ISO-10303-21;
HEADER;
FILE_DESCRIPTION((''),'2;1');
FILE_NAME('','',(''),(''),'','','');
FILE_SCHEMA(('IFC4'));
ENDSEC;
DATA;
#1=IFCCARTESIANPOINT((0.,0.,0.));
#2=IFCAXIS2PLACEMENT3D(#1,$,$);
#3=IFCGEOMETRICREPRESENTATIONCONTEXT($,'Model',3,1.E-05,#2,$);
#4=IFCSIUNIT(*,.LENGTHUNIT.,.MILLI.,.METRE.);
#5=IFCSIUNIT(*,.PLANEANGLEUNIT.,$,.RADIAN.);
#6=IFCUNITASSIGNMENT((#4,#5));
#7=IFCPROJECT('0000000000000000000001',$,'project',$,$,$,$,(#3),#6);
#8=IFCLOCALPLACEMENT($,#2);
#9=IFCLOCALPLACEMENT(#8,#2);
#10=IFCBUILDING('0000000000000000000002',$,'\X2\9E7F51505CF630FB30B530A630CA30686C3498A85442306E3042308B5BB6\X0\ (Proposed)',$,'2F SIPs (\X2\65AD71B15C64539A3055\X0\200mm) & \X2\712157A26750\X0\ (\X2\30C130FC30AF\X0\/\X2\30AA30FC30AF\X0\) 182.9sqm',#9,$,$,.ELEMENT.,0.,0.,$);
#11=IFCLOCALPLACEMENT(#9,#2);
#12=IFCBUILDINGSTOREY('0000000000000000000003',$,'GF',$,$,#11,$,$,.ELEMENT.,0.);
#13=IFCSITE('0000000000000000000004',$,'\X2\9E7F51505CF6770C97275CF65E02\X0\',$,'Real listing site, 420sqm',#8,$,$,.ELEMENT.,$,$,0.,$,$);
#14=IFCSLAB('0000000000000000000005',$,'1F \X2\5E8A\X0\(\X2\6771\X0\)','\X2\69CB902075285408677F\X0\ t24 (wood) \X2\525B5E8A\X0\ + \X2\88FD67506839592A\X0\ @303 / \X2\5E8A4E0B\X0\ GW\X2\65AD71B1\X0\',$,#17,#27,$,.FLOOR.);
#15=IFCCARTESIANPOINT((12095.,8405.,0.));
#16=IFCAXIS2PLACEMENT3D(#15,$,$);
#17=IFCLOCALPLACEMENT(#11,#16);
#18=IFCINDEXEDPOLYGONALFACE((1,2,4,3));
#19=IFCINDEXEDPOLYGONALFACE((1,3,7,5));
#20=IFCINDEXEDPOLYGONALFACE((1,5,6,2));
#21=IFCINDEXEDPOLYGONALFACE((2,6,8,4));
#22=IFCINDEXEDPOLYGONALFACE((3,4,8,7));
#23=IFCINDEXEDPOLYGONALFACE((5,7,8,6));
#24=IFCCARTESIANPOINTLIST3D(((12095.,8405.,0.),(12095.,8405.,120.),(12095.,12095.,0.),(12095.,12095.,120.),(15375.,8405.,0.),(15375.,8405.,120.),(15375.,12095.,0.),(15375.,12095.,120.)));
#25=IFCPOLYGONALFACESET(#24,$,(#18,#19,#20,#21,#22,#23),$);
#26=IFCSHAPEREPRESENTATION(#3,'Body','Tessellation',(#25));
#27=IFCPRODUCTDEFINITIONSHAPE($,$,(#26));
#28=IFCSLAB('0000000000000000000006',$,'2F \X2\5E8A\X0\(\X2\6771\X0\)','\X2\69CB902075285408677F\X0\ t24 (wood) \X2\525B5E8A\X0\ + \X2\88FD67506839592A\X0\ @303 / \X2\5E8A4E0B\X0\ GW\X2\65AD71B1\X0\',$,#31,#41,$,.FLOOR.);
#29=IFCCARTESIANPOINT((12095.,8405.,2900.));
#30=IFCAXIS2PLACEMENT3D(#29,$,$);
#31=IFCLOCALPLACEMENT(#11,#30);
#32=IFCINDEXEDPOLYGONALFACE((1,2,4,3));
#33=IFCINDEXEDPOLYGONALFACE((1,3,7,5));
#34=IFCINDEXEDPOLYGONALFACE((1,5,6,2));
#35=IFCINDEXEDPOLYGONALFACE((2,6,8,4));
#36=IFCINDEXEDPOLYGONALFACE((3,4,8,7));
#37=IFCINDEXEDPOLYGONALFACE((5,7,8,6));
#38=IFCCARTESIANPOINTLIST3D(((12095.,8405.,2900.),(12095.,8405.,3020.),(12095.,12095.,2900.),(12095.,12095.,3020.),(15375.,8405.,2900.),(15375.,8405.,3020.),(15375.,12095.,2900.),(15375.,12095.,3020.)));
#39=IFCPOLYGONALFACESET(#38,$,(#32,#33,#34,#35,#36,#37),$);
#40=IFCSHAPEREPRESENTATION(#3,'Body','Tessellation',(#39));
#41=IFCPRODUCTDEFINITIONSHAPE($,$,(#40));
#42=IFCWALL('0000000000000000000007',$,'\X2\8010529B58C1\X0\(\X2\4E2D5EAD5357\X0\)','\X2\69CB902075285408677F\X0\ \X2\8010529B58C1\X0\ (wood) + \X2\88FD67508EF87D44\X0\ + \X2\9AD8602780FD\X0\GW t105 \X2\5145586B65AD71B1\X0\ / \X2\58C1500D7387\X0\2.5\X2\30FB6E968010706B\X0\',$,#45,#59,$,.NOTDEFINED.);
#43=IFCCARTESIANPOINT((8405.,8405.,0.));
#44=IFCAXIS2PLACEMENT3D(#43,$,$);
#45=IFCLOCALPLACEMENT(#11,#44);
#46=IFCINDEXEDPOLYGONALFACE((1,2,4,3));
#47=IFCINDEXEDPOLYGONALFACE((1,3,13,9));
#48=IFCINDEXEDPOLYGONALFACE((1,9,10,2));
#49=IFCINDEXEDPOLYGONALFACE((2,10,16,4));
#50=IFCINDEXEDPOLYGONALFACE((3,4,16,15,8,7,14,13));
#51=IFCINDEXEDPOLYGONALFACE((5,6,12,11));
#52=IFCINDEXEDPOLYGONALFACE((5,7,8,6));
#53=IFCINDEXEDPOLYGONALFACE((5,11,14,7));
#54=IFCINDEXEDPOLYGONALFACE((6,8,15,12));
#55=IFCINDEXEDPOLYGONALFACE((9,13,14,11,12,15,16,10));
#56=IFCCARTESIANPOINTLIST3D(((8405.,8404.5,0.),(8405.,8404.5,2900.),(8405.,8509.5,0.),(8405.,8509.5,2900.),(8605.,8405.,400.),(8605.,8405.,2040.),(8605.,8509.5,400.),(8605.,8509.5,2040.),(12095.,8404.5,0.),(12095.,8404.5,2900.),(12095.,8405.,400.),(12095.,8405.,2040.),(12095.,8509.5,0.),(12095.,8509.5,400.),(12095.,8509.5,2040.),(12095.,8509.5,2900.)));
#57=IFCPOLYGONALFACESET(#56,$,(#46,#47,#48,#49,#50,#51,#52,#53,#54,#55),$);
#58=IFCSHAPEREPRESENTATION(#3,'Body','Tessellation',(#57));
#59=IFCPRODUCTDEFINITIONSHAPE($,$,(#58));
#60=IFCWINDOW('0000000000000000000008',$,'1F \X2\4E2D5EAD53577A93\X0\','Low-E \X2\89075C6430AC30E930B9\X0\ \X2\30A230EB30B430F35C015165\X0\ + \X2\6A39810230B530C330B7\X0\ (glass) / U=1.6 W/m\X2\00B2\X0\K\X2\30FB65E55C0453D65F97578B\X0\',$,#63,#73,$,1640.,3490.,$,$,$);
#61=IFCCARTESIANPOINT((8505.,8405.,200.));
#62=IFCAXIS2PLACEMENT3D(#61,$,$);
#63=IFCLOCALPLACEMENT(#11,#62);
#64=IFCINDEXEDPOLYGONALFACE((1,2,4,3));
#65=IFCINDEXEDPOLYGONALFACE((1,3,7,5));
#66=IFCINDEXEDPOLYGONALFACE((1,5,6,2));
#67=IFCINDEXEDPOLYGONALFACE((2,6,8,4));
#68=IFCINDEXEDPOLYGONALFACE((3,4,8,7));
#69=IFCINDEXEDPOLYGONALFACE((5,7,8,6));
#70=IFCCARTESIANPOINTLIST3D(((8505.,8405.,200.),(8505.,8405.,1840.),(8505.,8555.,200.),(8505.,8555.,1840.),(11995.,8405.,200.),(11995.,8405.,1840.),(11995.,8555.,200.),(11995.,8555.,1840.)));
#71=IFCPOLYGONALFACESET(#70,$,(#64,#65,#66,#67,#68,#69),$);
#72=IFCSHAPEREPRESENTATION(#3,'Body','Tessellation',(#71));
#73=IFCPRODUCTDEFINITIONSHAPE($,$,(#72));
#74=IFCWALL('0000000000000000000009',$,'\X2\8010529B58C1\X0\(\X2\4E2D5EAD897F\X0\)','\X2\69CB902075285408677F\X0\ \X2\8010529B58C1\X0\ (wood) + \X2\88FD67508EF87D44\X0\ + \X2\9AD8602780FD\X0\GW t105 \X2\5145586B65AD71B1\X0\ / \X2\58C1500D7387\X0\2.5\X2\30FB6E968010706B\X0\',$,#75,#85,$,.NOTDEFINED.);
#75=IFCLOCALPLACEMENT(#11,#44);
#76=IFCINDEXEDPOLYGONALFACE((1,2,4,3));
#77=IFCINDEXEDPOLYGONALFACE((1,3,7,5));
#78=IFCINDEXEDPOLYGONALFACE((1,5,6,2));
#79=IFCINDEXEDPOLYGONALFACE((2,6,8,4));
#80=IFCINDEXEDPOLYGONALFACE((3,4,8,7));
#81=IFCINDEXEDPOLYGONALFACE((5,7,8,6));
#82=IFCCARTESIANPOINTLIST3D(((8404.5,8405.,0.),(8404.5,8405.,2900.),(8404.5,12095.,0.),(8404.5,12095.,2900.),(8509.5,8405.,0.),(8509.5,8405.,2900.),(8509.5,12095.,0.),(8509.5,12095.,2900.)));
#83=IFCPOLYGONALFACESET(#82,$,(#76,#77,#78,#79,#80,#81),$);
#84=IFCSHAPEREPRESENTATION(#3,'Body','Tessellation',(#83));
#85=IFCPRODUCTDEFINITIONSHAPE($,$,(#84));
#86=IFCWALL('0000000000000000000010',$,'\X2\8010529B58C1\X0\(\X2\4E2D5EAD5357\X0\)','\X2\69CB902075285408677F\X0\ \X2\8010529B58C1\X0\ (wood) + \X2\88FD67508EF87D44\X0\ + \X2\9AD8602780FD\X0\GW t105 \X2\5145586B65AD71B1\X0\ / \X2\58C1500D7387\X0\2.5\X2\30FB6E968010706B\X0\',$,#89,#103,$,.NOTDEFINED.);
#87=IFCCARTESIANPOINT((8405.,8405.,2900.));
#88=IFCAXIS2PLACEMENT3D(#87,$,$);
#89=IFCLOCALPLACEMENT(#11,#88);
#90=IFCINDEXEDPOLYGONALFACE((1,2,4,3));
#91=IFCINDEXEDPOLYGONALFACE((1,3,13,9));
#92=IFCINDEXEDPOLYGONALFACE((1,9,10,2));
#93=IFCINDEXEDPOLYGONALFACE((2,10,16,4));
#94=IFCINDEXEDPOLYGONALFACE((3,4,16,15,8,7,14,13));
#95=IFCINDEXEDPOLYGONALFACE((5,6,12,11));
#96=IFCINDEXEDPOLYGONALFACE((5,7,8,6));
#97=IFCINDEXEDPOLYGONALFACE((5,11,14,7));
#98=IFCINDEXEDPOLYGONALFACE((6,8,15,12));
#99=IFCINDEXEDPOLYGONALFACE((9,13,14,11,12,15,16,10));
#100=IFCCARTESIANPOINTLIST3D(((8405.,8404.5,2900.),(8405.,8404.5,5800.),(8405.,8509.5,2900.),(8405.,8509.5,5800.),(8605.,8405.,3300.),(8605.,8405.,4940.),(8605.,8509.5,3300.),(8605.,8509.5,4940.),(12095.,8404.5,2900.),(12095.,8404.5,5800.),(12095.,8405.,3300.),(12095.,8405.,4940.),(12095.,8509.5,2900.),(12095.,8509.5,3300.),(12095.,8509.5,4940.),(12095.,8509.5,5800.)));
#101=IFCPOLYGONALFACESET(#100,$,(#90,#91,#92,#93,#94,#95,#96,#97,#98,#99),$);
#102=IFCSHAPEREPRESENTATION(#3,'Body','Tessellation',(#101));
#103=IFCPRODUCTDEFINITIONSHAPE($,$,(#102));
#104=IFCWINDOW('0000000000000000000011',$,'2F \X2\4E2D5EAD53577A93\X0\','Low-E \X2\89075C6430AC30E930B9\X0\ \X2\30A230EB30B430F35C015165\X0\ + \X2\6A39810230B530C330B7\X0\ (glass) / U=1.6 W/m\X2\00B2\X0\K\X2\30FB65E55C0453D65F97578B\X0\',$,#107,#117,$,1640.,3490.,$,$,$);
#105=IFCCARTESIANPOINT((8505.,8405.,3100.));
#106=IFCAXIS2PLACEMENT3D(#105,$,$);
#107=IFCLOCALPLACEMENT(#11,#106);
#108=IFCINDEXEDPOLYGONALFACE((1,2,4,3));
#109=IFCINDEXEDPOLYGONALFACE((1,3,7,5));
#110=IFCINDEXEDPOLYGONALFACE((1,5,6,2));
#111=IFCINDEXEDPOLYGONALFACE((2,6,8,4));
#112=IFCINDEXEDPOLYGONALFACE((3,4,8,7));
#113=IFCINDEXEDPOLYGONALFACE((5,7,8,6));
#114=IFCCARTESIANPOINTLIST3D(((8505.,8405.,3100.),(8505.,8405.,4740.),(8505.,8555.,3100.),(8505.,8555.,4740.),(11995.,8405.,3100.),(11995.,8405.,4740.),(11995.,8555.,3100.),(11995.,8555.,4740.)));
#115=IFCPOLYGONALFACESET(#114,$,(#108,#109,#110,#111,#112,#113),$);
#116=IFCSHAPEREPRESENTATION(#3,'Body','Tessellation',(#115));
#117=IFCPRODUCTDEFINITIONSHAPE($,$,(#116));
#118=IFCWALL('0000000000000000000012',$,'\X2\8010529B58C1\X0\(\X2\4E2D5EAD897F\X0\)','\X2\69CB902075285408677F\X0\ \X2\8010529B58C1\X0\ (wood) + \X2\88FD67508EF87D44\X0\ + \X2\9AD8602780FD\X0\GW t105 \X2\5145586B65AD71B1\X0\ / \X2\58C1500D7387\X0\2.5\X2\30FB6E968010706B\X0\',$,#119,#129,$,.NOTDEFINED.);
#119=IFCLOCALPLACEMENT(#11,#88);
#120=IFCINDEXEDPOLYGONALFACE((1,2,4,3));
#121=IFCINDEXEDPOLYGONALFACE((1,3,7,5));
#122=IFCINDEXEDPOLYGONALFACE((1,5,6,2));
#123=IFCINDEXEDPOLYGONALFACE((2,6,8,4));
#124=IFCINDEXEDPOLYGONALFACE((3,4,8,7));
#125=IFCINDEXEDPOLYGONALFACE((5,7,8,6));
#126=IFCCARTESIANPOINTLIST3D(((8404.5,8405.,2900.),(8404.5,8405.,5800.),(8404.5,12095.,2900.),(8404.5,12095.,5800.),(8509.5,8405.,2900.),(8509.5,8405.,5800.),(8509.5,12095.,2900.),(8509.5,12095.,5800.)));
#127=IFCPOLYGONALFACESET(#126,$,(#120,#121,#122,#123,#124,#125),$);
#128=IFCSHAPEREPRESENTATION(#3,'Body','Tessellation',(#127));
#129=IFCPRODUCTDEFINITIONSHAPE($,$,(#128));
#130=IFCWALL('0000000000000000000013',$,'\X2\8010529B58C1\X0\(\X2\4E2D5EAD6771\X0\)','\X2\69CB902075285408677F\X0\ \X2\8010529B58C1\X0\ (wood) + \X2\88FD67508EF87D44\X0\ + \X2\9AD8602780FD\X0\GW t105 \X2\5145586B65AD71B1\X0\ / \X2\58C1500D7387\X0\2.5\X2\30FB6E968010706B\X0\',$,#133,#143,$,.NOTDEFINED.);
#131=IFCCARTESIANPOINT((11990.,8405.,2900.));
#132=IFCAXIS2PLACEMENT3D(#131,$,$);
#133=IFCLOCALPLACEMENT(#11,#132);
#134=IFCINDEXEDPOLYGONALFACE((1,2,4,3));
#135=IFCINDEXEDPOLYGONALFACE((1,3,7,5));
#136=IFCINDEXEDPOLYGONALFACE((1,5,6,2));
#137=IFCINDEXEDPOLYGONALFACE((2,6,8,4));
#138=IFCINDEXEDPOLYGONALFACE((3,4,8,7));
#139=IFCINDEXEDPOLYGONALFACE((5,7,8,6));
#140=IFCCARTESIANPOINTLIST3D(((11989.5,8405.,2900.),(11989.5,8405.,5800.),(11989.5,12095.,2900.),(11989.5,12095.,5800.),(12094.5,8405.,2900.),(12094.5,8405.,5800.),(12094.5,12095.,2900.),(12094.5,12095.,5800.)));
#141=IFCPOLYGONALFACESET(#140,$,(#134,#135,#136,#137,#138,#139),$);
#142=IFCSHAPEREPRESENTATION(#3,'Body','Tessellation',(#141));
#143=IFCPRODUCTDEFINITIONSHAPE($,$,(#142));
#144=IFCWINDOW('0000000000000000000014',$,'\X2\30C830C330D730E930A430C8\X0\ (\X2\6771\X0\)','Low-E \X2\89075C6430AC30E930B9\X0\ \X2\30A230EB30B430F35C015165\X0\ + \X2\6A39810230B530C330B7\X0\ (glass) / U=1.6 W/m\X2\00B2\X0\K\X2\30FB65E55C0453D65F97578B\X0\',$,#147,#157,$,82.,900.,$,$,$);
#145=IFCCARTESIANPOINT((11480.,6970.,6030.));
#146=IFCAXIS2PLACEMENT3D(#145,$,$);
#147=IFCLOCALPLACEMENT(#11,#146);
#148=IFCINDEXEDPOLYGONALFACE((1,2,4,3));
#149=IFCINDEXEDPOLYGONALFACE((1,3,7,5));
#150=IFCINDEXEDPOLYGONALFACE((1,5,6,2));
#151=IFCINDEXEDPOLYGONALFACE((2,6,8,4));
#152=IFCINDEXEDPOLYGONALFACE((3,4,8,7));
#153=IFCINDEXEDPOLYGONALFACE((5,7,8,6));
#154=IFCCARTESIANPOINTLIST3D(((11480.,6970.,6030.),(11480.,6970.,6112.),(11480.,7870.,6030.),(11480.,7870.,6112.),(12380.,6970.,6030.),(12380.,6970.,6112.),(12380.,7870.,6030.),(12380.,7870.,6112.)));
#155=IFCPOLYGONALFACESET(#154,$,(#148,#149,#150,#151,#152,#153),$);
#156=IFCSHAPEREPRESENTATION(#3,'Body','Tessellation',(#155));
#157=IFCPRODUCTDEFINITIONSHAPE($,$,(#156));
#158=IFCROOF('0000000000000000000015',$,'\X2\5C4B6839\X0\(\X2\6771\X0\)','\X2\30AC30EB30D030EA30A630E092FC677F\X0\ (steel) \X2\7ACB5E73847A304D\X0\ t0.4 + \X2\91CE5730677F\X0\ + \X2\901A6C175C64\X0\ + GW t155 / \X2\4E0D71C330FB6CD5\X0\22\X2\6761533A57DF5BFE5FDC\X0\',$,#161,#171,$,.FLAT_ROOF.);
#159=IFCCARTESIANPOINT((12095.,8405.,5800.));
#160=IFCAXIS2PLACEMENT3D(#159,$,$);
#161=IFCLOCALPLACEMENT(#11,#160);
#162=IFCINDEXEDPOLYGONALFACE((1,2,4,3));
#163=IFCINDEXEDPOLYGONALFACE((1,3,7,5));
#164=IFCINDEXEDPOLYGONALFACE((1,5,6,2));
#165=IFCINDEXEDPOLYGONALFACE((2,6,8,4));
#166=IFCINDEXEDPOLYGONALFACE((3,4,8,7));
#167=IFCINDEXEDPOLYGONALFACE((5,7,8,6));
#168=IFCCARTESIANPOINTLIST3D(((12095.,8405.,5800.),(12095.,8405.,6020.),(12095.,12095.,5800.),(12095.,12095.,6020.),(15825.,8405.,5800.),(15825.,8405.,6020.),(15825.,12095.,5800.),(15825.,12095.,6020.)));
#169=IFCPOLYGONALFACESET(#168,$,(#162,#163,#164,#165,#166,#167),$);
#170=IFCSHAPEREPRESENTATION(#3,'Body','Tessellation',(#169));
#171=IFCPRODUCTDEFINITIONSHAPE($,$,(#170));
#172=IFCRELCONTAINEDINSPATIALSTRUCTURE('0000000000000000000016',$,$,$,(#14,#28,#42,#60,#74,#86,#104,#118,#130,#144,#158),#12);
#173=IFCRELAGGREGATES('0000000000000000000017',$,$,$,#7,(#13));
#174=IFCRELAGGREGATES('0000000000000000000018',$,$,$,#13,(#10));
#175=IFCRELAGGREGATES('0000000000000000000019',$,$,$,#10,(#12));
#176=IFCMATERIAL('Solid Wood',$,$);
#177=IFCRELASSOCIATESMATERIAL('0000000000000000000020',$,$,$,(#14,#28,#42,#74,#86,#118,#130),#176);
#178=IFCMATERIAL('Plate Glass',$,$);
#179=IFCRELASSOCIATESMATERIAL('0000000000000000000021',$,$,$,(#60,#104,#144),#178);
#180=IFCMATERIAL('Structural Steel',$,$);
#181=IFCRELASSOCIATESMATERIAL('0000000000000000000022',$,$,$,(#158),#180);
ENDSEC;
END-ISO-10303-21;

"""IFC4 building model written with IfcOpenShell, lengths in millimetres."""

from ifc_helpers import new_model, si_unit, frame, frame_2d, origin, place, context, project, spatial, rectangle, extrude, material, element, fill, save


model = new_model("IFC4")

# Units and contexts
model_context = context("Model", 3, precision=1e-05, world=origin())
ifc_project = project(units=[si_unit("LENGTHUNIT", "METRE", prefix="MILLI"), si_unit("PLANEANGLEUNIT", "RADIAN")], contexts=[model_context])

# Site, building, storey
site_placement = place(None, origin())
site = spatial("IfcSite", under=ifc_project, at=site_placement, Name="鹿児島県霧島市", ObjectType="Real listing site, 420sqm", CompositionType="ELEMENT", RefElevation=0.0)
building_placement = place(site_placement, origin())
building = spatial("IfcBuilding", under=site, at=building_placement, Name="鹿児島・サウナと水風呂のある家 (Proposed)", ObjectType="2F SIPs (断熱層厚さ200mm) & 無垢材 (チーク/オーク) 182.9sqm", CompositionType="ELEMENT", ElevationOfRefHeight=0.0, ElevationOfTerrain=0.0)
storey_placement = place(building_placement, origin())
storey = spatial("IfcBuildingStorey", under=building, at=storey_placement, Name="GF", CompositionType="ELEMENT", Elevation=0.0)

# Shared definitions
ifc_material_1 = material(Name="Solid Wood")

# Slabs
slab_1_placement = place(storey_placement, frame((12095.0, 8405.0, 0.0)))
element("IfcSlab", 1, at=slab_1_placement, inside=storey, material=ifc_material_1, Name="1F 床(東)", Description="構造用合板 t24 (wood) 剛床 + 製材根太 @303 / 床下 GW断熱", PredefinedType="FLOOR", context=model_context, shape_type="SweptSolid", body=[
    extrude(rectangle(XDim=3280.0, YDim=3690.0, at=frame_2d((1640.0, 1845.0))), frame((12095.0, 8405.0, 0.0)), (0.0, 0.0, 1.0), 120.0),
])
slab_2_placement = place(storey_placement, frame((12095.0, 8405.0, 2900.0)))
element("IfcSlab", 2, at=slab_2_placement, inside=storey, material=ifc_material_1, Name="2F 床(東)", Description="構造用合板 t24 (wood) 剛床 + 製材根太 @303 / 床下 GW断熱", PredefinedType="FLOOR", context=model_context, shape_type="SweptSolid", body=[
    extrude(rectangle(XDim=3280.0, YDim=3690.0, at=frame_2d((1640.0, 1845.0))), frame((12095.0, 8405.0, 2900.0)), (0.0, 0.0, 1.0), 120.0),
])

# Wall, opening, window
wall_1_placement = place(storey_placement, frame((8405.0, 8405.0, 0.0)))
wall_1 = element("IfcWall", 3, at=wall_1_placement, inside=storey, material=ifc_material_1, Name="耐力壁(中庭南)", Description="構造用合板 耐力壁 (wood) + 製材軸組 + 高性能GW t105 充填断熱 / 壁倍率2.5・準耐火", PredefinedType="NOTDEFINED", context=model_context, shape_type="SweptSolid", body=[
    extrude(rectangle(XDim=3690.0, YDim=105.0, at=frame_2d((1845.0, 52.0))), frame((8405.0, 8405.0, 0.0)), (0.0, 0.0, 1.0), 2900.0),
])
opening_1_placement = place(storey_placement, frame((8505.0, 8405.0, 200.0)))
opening_1 = element("IfcOpeningElement", 4, at=opening_1_placement, cuts=wall_1, PredefinedType="NOTDEFINED", context=model_context, shape_type="SweptSolid", body=[
    extrude(rectangle(XDim=3490.0, YDim=150.0, at=frame_2d((1745.0, 75.0))), frame((8505.0, 8405.0, 200.0)), (0.0, 0.0, 1.0), 1640.0),
])
ifc_material_2 = material(Name="Plate Glass")
window_1_placement = place(storey_placement, frame((8505.0, 8405.0, 200.0)))
window_1 = element("IfcWindow", 5, at=window_1_placement, inside=storey, material=ifc_material_2, Name="1F 中庭南窓", Description="Low-E 複層ガラス アルゴン封入 + 樹脂サッシ (glass) / U=1.6 W/m²K・日射取得型", OverallHeight=1640.0, OverallWidth=3490.0, context=model_context, shape_type="SweptSolid", body=[
    extrude(rectangle(XDim=3490.0, YDim=150.0, at=frame_2d((1745.0, 75.0))), frame((8505.0, 8405.0, 200.0)), (0.0, 0.0, 1.0), 1640.0),
])
fill(opening_1, window_1)

# Wall
wall_2_placement = place(storey_placement, frame((8405.0, 8405.0, 0.0)))
element("IfcWall", 6, at=wall_2_placement, inside=storey, material=ifc_material_1, Name="耐力壁(中庭西)", Description="構造用合板 耐力壁 (wood) + 製材軸組 + 高性能GW t105 充填断熱 / 壁倍率2.5・準耐火", PredefinedType="NOTDEFINED", context=model_context, shape_type="SweptSolid", body=[
    extrude(rectangle(XDim=105.0, YDim=3690.0, at=frame_2d((52.0, 1845.0))), frame((8405.0, 8405.0, 0.0)), (0.0, 0.0, 1.0), 2900.0),
])

# Wall, opening, window
wall_3_placement = place(storey_placement, frame((8405.0, 8405.0, 2900.0)))
wall_3 = element("IfcWall", 7, at=wall_3_placement, inside=storey, material=ifc_material_1, Name="耐力壁(中庭南)", Description="構造用合板 耐力壁 (wood) + 製材軸組 + 高性能GW t105 充填断熱 / 壁倍率2.5・準耐火", PredefinedType="NOTDEFINED", context=model_context, shape_type="SweptSolid", body=[
    extrude(rectangle(XDim=3690.0, YDim=105.0, at=frame_2d((1845.0, 52.0))), frame((8405.0, 8405.0, 2900.0)), (0.0, 0.0, 1.0), 2900.0),
])
opening_2_placement = place(storey_placement, frame((8505.0, 8405.0, 3100.0)))
opening_2 = element("IfcOpeningElement", 8, at=opening_2_placement, cuts=wall_3, PredefinedType="NOTDEFINED", context=model_context, shape_type="SweptSolid", body=[
    extrude(rectangle(XDim=3490.0, YDim=150.0, at=frame_2d((1745.0, 75.0))), frame((8505.0, 8405.0, 3100.0)), (0.0, 0.0, 1.0), 1640.0),
])
window_2_placement = place(storey_placement, frame((8505.0, 8405.0, 3100.0)))
window_2 = element("IfcWindow", 9, at=window_2_placement, inside=storey, material=ifc_material_2, Name="2F 中庭南窓", Description="Low-E 複層ガラス アルゴン封入 + 樹脂サッシ (glass) / U=1.6 W/m²K・日射取得型", OverallHeight=1640.0, OverallWidth=3490.0, context=model_context, shape_type="SweptSolid", body=[
    extrude(rectangle(XDim=3490.0, YDim=150.0, at=frame_2d((1745.0, 75.0))), frame((8505.0, 8405.0, 3100.0)), (0.0, 0.0, 1.0), 1640.0),
])
fill(opening_2, window_2)

# Walls
wall_4_placement = place(storey_placement, frame((8405.0, 8405.0, 2900.0)))
element("IfcWall", 10, at=wall_4_placement, inside=storey, material=ifc_material_1, Name="耐力壁(中庭西)", Description="構造用合板 耐力壁 (wood) + 製材軸組 + 高性能GW t105 充填断熱 / 壁倍率2.5・準耐火", PredefinedType="NOTDEFINED", context=model_context, shape_type="SweptSolid", body=[
    extrude(rectangle(XDim=105.0, YDim=3690.0, at=frame_2d((52.0, 1845.0))), frame((8405.0, 8405.0, 2900.0)), (0.0, 0.0, 1.0), 2900.0),
])
wall_5_placement = place(storey_placement, frame((11990.0, 8405.0, 2900.0)))
element("IfcWall", 11, at=wall_5_placement, inside=storey, material=ifc_material_1, Name="耐力壁(中庭東)", Description="構造用合板 耐力壁 (wood) + 製材軸組 + 高性能GW t105 充填断熱 / 壁倍率2.5・準耐火", PredefinedType="NOTDEFINED", context=model_context, shape_type="SweptSolid", body=[
    extrude(rectangle(XDim=105.0, YDim=3690.0, at=frame_2d((52.0, 1845.0))), frame((11990.0, 8405.0, 2900.0)), (0.0, 0.0, 1.0), 2900.0),
])

# Window
window_3_placement = place(storey_placement, frame((11480.0, 6970.0, 6030.0)))
element("IfcWindow", 12, at=window_3_placement, inside=storey, material=ifc_material_2, Name="トップライト (東)", Description="Low-E 複層ガラス アルゴン封入 + 樹脂サッシ (glass) / U=1.6 W/m²K・日射取得型", OverallHeight=82.0, OverallWidth=900.0, context=model_context, shape_type="SweptSolid", body=[
    extrude(rectangle(XDim=900.0, YDim=900.0, at=frame_2d((450.0, 450.0))), frame((11480.0, 6970.0, 6030.0)), (0.0, 0.0, 1.0), 82.0),
])

# Roof
ifc_material_3 = material(Name="Structural Steel")
roof_placement = place(storey_placement, frame((12095.0, 8405.0, 5800.0)))
element("IfcRoof", 13, at=roof_placement, inside=storey, material=ifc_material_3, Name="屋根(東)", Description="ガルバリウム鋼板 (steel) 立平葺き t0.4 + 野地板 + 通気層 + GW t155 / 不燃・法22条区域対応", PredefinedType="FLAT_ROOF", context=model_context, shape_type="SweptSolid", body=[
    extrude(rectangle(XDim=3730.0, YDim=3690.0, at=frame_2d((1865.0, 1845.0))), frame((12095.0, 8405.0, 5800.0)), (0.0, 0.0, 1.0), 220.0),
])

save(model, "model.ifc")
